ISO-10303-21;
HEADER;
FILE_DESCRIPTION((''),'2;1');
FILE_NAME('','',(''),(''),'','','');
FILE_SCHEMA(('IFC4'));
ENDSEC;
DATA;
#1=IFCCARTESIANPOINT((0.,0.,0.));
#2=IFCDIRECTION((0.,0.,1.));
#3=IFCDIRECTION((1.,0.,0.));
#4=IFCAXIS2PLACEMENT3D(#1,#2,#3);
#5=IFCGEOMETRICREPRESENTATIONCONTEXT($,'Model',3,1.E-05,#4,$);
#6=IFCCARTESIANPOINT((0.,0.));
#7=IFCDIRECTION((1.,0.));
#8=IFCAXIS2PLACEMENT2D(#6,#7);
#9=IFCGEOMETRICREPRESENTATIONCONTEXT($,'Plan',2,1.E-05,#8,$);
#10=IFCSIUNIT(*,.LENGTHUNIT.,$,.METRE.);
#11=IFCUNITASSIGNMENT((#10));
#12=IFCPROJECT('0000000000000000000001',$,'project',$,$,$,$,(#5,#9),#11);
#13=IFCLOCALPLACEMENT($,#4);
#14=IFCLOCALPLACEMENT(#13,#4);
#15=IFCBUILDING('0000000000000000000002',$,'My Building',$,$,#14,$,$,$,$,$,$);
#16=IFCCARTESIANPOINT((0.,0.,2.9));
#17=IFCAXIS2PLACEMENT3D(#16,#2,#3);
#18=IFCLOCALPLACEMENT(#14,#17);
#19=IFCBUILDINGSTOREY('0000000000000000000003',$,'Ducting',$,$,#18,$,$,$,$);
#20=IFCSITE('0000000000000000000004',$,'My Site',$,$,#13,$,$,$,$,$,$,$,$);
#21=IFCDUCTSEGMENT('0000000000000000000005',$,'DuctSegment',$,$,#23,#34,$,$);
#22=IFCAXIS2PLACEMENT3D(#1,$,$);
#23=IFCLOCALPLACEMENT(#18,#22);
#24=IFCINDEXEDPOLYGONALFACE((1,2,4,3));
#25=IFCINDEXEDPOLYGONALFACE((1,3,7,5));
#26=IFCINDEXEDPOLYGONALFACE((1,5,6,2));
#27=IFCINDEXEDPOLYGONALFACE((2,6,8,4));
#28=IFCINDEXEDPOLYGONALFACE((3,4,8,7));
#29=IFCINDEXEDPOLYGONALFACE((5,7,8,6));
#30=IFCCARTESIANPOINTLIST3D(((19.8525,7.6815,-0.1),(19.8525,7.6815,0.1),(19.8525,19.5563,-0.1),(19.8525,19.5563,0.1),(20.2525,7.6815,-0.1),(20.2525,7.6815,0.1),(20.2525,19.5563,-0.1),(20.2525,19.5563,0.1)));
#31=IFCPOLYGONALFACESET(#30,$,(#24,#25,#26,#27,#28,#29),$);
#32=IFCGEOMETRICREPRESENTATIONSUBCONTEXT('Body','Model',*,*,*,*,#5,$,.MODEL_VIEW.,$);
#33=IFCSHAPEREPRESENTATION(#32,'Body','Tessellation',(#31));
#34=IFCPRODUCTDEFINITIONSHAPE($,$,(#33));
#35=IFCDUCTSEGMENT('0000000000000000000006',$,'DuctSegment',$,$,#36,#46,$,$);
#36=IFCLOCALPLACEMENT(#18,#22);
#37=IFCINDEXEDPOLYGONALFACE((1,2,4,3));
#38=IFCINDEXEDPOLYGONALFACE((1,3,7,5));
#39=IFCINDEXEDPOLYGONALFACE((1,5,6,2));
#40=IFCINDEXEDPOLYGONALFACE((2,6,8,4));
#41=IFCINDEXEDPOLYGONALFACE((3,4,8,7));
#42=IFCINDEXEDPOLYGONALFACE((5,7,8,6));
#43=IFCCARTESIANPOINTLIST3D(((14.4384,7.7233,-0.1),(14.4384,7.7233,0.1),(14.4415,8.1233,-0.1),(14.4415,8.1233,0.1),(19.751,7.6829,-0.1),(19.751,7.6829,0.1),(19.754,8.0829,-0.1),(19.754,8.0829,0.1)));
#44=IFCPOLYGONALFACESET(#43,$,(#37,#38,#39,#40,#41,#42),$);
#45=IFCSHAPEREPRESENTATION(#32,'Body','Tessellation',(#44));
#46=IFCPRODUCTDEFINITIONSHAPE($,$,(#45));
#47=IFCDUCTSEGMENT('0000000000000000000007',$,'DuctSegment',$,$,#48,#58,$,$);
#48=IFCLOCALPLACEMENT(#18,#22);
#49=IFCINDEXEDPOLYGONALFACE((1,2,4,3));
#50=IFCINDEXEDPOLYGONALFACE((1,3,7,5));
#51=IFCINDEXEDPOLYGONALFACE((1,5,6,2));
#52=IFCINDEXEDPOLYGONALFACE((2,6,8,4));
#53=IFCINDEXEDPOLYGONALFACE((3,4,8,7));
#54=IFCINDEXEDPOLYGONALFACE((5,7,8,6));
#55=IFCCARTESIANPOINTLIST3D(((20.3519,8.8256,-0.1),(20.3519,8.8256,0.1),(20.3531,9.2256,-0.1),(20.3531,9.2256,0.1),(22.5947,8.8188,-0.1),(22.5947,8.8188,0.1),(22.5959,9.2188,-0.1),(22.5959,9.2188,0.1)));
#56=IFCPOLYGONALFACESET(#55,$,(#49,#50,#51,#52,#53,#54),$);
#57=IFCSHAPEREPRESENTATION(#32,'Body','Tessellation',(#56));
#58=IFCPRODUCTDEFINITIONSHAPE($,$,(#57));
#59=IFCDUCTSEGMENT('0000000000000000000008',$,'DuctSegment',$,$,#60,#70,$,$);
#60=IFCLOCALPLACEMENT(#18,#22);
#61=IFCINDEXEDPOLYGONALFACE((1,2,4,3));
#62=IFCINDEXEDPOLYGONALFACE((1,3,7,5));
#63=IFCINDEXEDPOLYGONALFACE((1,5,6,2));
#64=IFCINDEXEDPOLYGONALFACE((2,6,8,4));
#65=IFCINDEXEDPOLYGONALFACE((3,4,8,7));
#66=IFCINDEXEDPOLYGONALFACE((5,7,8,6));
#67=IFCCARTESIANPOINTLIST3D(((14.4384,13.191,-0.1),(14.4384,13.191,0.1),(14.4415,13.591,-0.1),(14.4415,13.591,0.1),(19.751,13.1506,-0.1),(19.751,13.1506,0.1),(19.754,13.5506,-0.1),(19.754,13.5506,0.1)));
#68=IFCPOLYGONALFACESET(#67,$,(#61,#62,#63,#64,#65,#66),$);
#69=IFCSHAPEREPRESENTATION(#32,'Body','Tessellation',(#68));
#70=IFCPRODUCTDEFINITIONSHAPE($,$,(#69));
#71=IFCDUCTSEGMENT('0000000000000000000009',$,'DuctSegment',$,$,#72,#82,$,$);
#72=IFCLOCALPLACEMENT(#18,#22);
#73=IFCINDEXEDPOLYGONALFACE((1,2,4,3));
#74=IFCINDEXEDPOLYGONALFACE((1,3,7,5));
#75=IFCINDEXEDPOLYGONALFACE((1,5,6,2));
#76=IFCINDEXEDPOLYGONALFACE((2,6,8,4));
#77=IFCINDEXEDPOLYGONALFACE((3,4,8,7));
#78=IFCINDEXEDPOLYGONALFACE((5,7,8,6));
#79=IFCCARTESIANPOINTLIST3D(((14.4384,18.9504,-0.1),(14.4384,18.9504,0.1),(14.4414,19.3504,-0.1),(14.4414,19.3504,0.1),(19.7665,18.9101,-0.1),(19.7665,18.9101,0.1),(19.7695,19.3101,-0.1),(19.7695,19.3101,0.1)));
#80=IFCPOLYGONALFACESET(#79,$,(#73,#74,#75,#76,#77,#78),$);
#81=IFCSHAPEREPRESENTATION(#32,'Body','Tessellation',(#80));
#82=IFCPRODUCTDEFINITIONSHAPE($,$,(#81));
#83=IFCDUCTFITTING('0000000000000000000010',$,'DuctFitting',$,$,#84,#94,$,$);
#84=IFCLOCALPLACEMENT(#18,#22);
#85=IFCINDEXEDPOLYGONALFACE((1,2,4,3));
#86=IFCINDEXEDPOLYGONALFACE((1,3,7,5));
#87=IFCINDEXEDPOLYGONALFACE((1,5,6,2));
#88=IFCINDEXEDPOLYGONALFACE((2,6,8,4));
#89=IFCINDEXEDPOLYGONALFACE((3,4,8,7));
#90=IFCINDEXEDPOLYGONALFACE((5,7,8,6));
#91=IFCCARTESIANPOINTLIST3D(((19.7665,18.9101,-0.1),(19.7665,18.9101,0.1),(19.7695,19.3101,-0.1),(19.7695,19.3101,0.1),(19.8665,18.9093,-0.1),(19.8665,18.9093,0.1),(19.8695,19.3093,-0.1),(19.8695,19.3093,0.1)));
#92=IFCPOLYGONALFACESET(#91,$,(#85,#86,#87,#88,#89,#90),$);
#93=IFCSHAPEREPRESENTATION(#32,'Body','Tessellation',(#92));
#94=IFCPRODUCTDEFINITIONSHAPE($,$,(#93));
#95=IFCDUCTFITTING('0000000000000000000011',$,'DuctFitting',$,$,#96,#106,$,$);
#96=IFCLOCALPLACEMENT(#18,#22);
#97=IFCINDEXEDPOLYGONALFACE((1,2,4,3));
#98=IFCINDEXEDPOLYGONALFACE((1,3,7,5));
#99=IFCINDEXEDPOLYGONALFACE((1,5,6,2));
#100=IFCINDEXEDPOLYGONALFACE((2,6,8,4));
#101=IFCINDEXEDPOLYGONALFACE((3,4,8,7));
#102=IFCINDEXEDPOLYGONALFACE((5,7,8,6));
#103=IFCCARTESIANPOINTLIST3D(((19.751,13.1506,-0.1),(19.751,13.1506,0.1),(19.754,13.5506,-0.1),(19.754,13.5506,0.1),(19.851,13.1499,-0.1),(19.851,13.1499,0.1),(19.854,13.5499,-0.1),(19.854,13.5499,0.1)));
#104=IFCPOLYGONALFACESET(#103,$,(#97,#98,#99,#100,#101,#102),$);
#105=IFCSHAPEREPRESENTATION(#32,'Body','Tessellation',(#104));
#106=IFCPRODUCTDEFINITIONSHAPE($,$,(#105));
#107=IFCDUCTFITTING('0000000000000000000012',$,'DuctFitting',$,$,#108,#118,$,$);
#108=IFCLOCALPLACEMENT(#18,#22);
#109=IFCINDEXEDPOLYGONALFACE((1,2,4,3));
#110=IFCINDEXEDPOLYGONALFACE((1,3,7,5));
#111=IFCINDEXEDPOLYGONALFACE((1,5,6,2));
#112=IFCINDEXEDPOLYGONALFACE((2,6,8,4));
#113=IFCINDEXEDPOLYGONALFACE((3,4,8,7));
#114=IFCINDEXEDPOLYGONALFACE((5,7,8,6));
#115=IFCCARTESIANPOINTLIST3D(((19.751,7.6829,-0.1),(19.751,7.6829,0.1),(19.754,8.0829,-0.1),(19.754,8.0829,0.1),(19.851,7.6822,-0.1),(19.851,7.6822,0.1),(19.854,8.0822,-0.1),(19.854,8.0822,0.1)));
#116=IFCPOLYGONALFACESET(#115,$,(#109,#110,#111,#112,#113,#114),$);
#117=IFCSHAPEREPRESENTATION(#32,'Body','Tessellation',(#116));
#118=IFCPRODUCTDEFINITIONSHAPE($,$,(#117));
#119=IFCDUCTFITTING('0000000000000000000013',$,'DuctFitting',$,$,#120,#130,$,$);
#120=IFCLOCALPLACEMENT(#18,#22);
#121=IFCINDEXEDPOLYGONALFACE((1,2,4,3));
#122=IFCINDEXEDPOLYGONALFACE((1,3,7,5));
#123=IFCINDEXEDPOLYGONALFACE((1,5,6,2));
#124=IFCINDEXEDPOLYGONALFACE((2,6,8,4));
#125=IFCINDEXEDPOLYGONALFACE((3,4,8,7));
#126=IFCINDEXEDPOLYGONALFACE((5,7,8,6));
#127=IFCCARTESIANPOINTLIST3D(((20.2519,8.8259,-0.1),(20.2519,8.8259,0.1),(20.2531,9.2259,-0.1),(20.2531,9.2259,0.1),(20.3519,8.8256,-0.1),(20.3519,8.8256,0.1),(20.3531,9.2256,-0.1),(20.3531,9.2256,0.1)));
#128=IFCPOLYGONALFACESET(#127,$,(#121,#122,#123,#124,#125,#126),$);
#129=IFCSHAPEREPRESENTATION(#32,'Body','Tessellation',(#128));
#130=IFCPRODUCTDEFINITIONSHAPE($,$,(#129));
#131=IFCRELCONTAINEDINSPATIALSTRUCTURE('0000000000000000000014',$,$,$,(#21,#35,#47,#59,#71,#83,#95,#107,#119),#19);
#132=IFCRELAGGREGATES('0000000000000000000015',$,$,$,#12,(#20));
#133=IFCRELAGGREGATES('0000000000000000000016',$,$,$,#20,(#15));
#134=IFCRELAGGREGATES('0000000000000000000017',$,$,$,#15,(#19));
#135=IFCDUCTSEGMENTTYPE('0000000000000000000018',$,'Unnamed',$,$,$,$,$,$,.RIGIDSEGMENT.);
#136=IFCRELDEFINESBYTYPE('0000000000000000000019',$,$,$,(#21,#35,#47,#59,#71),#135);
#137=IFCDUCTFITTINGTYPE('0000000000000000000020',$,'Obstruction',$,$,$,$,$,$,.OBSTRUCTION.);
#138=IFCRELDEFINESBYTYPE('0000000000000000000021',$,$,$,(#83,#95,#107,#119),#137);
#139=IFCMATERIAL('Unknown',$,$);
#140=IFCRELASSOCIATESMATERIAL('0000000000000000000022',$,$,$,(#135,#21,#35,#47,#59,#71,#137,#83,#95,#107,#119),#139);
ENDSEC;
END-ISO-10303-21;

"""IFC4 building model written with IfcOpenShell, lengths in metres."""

from ifc_helpers import new_model, si_unit, frame, origin_with_axes, origin_2d_with_axis, place, context, subcontext, project, spatial, rectangle, extrude, material, material_profile, profile_set, profile_usage, type_object, element, save


model = new_model("IFC4")

# Units and contexts
model_context = context("Model", 3, precision=1e-05, world=origin_with_axes())
plan_context = context("Plan", 2, precision=1e-05, world=origin_2d_with_axis())
body_context = subcontext(model_context, "Body", "Model", "MODEL_VIEW")
ifc_project = project(units=[si_unit("LENGTHUNIT", "METRE")], contexts=[model_context, plan_context])

# Site, building, storey
site_placement = place(None, origin_with_axes())
site = spatial("IfcSite", under=ifc_project, at=site_placement, Name="My Site")
building_placement = place(site_placement, origin_with_axes())
building = spatial("IfcBuilding", under=site, at=building_placement, Name="My Building")
storey_placement = place(building_placement, frame((0.0, 0.0, 2.9), z_axis=(0.0, 0.0, 1.0), x_axis=(1.0, 0.0, 0.0)))
storey = spatial("IfcBuildingStorey", under=building, at=storey_placement, Name="Ducting")

# Duct segments
ifc_material = material(Name="Unknown")
ifc_material_profile_1 = material_profile(ifc_material, rectangle(XDim=0.4, YDim=0.2))
ifc_profile_set_1 = profile_set([ifc_material_profile_1])
ifc_profile_usage_1 = profile_usage(ifc_profile_set_1, cardinal=5)
duct_segment_type = type_object("IfcDuctSegmentType", Name="Unnamed", PredefinedType="RIGIDSEGMENT", material=ifc_profile_set_1)
duct_segment_1_placement = place(storey_placement, frame((20.0525, 19.5563, 0.0), z_axis=(0.0, -1.0, 0.0), x_axis=(1.0, 0.0, 0.0)))
element("IfcDuctSegment", 1, at=duct_segment_1_placement, inside=storey, type_object=duct_segment_type, material=ifc_profile_usage_1, Name="DuctSegment", context=body_context, shape_type="SweptSolid", body=[
    extrude(rectangle(XDim=0.4, YDim=0.2), origin_with_axes(), (0.0, 0.0, 1.0), 11.8749),
])
ifc_profile_usage_2 = profile_usage(ifc_profile_set_1, cardinal=5)
duct_segment_2_placement = place(storey_placement, frame((19.7525, 7.8829, 0.0), z_axis=(-0.999971, 0.007595, 0.0), x_axis=(-0.007595, -0.999971, 0.0)))
element("IfcDuctSegment", 2, at=duct_segment_2_placement, inside=storey, type_object=duct_segment_type, material=ifc_profile_usage_2, Name="DuctSegment", context=body_context, shape_type="SweptSolid", body=[
    extrude(rectangle(XDim=0.4, YDim=0.2), origin_with_axes(), (0.0, 0.0, 1.0), 5.3127),
])
ifc_profile_usage_3 = profile_usage(ifc_profile_set_1, cardinal=5)
duct_segment_3_placement = place(storey_placement, frame((20.3525, 9.0256, 0.0), z_axis=(0.999995, -0.003018, 0.0), x_axis=(0.003018, 0.999995, 0.0)))
element("IfcDuctSegment", 3, at=duct_segment_3_placement, inside=storey, type_object=duct_segment_type, material=ifc_profile_usage_3, Name="DuctSegment", context=body_context, shape_type="SweptSolid", body=[
    extrude(rectangle(XDim=0.4, YDim=0.2), origin_with_axes(), (0.0, 0.0, 1.0), 2.2428),
])
ifc_profile_usage_4 = profile_usage(ifc_profile_set_1, cardinal=5)
duct_segment_4_placement = place(storey_placement, frame((19.7525, 13.3506, 0.0), z_axis=(-0.999971, 0.007595, 0.0), x_axis=(-0.007595, -0.999971, 0.0)))
element("IfcDuctSegment", 4, at=duct_segment_4_placement, inside=storey, type_object=duct_segment_type, material=ifc_profile_usage_4, Name="DuctSegment", context=body_context, shape_type="SweptSolid", body=[
    extrude(rectangle(XDim=0.4, YDim=0.2), origin_with_axes(), (0.0, 0.0, 1.0), 5.3127),
])
ifc_profile_usage_5 = profile_usage(ifc_profile_set_1, cardinal=5)
duct_segment_5_placement = place(storey_placement, frame((19.768, 19.1101, 0.0), z_axis=(-0.999971, 0.007573, 0.0), x_axis=(-0.007573, -0.999971, 0.0)))
element("IfcDuctSegment", 5, at=duct_segment_5_placement, inside=storey, type_object=duct_segment_type, material=ifc_profile_usage_5, Name="DuctSegment", context=body_context, shape_type="SweptSolid", body=[
    extrude(rectangle(XDim=0.4, YDim=0.2), origin_with_axes(), (0.0, 0.0, 1.0), 5.3282),
])

# Duct fittings
ifc_material_profile_2 = material_profile(ifc_material, rectangle(XDim=0.4, YDim=0.2))
ifc_profile_set_2 = profile_set([ifc_material_profile_2])
ifc_profile_usage_6 = profile_usage(ifc_profile_set_2, cardinal=5)
duct_fitting_type = type_object("IfcDuctFittingType", Name="Obstruction", PredefinedType="OBSTRUCTION", material=ifc_profile_set_2)
duct_fitting_1_placement = place(storey_placement, frame((19.868, 19.1093, 0.0), z_axis=(-0.999971, 0.007573, 0.0), x_axis=(-0.007573, -0.999971, 0.0)))
element("IfcDuctFitting", 6, at=duct_fitting_1_placement, inside=storey, type_object=duct_fitting_type, material=ifc_profile_usage_6, Name="DuctFitting", context=body_context, shape_type="SweptSolid", body=[
    extrude(rectangle(XDim=0.4, YDim=0.2), origin_with_axes(), (0.0, 0.0, 1.0), 0.1),
])
ifc_profile_usage_7 = profile_usage(ifc_profile_set_2, cardinal=5)
duct_fitting_2_placement = place(storey_placement, frame((19.8525, 13.3499, 0.0), z_axis=(-0.999971, 0.007595, 0.0), x_axis=(-0.007595, -0.999971, 0.0)))
element("IfcDuctFitting", 7, at=duct_fitting_2_placement, inside=storey, type_object=duct_fitting_type, material=ifc_profile_usage_7, Name="DuctFitting", context=body_context, shape_type="SweptSolid", body=[
    extrude(rectangle(XDim=0.4, YDim=0.2), origin_with_axes(), (0.0, 0.0, 1.0), 0.1),
])
ifc_profile_usage_8 = profile_usage(ifc_profile_set_2, cardinal=5)
duct_fitting_3_placement = place(storey_placement, frame((19.8525, 7.8822, 0.0), z_axis=(-0.999971, 0.007595, 0.0), x_axis=(-0.007595, -0.999971, 0.0)))
element("IfcDuctFitting", 8, at=duct_fitting_3_placement, inside=storey, type_object=duct_fitting_type, material=ifc_profile_usage_8, Name="DuctFitting", context=body_context, shape_type="SweptSolid", body=[
    extrude(rectangle(XDim=0.4, YDim=0.2), origin_with_axes(), (0.0, 0.0, 1.0), 0.1),
])
ifc_profile_usage_9 = profile_usage(ifc_profile_set_2, cardinal=5)
duct_fitting_4_placement = place(storey_placement, frame((20.2525, 9.0259, 0.0), z_axis=(0.999995, -0.003018, 0.0), x_axis=(0.003018, 0.999995, 0.0)))
element("IfcDuctFitting", 9, at=duct_fitting_4_placement, inside=storey, type_object=duct_fitting_type, material=ifc_profile_usage_9, Name="DuctFitting", context=body_context, shape_type="SweptSolid", body=[
    extrude(rectangle(XDim=0.4, YDim=0.2), origin_with_axes(), (0.0, 0.0, 1.0), 0.1),
])

save(model, "model.ifc")
